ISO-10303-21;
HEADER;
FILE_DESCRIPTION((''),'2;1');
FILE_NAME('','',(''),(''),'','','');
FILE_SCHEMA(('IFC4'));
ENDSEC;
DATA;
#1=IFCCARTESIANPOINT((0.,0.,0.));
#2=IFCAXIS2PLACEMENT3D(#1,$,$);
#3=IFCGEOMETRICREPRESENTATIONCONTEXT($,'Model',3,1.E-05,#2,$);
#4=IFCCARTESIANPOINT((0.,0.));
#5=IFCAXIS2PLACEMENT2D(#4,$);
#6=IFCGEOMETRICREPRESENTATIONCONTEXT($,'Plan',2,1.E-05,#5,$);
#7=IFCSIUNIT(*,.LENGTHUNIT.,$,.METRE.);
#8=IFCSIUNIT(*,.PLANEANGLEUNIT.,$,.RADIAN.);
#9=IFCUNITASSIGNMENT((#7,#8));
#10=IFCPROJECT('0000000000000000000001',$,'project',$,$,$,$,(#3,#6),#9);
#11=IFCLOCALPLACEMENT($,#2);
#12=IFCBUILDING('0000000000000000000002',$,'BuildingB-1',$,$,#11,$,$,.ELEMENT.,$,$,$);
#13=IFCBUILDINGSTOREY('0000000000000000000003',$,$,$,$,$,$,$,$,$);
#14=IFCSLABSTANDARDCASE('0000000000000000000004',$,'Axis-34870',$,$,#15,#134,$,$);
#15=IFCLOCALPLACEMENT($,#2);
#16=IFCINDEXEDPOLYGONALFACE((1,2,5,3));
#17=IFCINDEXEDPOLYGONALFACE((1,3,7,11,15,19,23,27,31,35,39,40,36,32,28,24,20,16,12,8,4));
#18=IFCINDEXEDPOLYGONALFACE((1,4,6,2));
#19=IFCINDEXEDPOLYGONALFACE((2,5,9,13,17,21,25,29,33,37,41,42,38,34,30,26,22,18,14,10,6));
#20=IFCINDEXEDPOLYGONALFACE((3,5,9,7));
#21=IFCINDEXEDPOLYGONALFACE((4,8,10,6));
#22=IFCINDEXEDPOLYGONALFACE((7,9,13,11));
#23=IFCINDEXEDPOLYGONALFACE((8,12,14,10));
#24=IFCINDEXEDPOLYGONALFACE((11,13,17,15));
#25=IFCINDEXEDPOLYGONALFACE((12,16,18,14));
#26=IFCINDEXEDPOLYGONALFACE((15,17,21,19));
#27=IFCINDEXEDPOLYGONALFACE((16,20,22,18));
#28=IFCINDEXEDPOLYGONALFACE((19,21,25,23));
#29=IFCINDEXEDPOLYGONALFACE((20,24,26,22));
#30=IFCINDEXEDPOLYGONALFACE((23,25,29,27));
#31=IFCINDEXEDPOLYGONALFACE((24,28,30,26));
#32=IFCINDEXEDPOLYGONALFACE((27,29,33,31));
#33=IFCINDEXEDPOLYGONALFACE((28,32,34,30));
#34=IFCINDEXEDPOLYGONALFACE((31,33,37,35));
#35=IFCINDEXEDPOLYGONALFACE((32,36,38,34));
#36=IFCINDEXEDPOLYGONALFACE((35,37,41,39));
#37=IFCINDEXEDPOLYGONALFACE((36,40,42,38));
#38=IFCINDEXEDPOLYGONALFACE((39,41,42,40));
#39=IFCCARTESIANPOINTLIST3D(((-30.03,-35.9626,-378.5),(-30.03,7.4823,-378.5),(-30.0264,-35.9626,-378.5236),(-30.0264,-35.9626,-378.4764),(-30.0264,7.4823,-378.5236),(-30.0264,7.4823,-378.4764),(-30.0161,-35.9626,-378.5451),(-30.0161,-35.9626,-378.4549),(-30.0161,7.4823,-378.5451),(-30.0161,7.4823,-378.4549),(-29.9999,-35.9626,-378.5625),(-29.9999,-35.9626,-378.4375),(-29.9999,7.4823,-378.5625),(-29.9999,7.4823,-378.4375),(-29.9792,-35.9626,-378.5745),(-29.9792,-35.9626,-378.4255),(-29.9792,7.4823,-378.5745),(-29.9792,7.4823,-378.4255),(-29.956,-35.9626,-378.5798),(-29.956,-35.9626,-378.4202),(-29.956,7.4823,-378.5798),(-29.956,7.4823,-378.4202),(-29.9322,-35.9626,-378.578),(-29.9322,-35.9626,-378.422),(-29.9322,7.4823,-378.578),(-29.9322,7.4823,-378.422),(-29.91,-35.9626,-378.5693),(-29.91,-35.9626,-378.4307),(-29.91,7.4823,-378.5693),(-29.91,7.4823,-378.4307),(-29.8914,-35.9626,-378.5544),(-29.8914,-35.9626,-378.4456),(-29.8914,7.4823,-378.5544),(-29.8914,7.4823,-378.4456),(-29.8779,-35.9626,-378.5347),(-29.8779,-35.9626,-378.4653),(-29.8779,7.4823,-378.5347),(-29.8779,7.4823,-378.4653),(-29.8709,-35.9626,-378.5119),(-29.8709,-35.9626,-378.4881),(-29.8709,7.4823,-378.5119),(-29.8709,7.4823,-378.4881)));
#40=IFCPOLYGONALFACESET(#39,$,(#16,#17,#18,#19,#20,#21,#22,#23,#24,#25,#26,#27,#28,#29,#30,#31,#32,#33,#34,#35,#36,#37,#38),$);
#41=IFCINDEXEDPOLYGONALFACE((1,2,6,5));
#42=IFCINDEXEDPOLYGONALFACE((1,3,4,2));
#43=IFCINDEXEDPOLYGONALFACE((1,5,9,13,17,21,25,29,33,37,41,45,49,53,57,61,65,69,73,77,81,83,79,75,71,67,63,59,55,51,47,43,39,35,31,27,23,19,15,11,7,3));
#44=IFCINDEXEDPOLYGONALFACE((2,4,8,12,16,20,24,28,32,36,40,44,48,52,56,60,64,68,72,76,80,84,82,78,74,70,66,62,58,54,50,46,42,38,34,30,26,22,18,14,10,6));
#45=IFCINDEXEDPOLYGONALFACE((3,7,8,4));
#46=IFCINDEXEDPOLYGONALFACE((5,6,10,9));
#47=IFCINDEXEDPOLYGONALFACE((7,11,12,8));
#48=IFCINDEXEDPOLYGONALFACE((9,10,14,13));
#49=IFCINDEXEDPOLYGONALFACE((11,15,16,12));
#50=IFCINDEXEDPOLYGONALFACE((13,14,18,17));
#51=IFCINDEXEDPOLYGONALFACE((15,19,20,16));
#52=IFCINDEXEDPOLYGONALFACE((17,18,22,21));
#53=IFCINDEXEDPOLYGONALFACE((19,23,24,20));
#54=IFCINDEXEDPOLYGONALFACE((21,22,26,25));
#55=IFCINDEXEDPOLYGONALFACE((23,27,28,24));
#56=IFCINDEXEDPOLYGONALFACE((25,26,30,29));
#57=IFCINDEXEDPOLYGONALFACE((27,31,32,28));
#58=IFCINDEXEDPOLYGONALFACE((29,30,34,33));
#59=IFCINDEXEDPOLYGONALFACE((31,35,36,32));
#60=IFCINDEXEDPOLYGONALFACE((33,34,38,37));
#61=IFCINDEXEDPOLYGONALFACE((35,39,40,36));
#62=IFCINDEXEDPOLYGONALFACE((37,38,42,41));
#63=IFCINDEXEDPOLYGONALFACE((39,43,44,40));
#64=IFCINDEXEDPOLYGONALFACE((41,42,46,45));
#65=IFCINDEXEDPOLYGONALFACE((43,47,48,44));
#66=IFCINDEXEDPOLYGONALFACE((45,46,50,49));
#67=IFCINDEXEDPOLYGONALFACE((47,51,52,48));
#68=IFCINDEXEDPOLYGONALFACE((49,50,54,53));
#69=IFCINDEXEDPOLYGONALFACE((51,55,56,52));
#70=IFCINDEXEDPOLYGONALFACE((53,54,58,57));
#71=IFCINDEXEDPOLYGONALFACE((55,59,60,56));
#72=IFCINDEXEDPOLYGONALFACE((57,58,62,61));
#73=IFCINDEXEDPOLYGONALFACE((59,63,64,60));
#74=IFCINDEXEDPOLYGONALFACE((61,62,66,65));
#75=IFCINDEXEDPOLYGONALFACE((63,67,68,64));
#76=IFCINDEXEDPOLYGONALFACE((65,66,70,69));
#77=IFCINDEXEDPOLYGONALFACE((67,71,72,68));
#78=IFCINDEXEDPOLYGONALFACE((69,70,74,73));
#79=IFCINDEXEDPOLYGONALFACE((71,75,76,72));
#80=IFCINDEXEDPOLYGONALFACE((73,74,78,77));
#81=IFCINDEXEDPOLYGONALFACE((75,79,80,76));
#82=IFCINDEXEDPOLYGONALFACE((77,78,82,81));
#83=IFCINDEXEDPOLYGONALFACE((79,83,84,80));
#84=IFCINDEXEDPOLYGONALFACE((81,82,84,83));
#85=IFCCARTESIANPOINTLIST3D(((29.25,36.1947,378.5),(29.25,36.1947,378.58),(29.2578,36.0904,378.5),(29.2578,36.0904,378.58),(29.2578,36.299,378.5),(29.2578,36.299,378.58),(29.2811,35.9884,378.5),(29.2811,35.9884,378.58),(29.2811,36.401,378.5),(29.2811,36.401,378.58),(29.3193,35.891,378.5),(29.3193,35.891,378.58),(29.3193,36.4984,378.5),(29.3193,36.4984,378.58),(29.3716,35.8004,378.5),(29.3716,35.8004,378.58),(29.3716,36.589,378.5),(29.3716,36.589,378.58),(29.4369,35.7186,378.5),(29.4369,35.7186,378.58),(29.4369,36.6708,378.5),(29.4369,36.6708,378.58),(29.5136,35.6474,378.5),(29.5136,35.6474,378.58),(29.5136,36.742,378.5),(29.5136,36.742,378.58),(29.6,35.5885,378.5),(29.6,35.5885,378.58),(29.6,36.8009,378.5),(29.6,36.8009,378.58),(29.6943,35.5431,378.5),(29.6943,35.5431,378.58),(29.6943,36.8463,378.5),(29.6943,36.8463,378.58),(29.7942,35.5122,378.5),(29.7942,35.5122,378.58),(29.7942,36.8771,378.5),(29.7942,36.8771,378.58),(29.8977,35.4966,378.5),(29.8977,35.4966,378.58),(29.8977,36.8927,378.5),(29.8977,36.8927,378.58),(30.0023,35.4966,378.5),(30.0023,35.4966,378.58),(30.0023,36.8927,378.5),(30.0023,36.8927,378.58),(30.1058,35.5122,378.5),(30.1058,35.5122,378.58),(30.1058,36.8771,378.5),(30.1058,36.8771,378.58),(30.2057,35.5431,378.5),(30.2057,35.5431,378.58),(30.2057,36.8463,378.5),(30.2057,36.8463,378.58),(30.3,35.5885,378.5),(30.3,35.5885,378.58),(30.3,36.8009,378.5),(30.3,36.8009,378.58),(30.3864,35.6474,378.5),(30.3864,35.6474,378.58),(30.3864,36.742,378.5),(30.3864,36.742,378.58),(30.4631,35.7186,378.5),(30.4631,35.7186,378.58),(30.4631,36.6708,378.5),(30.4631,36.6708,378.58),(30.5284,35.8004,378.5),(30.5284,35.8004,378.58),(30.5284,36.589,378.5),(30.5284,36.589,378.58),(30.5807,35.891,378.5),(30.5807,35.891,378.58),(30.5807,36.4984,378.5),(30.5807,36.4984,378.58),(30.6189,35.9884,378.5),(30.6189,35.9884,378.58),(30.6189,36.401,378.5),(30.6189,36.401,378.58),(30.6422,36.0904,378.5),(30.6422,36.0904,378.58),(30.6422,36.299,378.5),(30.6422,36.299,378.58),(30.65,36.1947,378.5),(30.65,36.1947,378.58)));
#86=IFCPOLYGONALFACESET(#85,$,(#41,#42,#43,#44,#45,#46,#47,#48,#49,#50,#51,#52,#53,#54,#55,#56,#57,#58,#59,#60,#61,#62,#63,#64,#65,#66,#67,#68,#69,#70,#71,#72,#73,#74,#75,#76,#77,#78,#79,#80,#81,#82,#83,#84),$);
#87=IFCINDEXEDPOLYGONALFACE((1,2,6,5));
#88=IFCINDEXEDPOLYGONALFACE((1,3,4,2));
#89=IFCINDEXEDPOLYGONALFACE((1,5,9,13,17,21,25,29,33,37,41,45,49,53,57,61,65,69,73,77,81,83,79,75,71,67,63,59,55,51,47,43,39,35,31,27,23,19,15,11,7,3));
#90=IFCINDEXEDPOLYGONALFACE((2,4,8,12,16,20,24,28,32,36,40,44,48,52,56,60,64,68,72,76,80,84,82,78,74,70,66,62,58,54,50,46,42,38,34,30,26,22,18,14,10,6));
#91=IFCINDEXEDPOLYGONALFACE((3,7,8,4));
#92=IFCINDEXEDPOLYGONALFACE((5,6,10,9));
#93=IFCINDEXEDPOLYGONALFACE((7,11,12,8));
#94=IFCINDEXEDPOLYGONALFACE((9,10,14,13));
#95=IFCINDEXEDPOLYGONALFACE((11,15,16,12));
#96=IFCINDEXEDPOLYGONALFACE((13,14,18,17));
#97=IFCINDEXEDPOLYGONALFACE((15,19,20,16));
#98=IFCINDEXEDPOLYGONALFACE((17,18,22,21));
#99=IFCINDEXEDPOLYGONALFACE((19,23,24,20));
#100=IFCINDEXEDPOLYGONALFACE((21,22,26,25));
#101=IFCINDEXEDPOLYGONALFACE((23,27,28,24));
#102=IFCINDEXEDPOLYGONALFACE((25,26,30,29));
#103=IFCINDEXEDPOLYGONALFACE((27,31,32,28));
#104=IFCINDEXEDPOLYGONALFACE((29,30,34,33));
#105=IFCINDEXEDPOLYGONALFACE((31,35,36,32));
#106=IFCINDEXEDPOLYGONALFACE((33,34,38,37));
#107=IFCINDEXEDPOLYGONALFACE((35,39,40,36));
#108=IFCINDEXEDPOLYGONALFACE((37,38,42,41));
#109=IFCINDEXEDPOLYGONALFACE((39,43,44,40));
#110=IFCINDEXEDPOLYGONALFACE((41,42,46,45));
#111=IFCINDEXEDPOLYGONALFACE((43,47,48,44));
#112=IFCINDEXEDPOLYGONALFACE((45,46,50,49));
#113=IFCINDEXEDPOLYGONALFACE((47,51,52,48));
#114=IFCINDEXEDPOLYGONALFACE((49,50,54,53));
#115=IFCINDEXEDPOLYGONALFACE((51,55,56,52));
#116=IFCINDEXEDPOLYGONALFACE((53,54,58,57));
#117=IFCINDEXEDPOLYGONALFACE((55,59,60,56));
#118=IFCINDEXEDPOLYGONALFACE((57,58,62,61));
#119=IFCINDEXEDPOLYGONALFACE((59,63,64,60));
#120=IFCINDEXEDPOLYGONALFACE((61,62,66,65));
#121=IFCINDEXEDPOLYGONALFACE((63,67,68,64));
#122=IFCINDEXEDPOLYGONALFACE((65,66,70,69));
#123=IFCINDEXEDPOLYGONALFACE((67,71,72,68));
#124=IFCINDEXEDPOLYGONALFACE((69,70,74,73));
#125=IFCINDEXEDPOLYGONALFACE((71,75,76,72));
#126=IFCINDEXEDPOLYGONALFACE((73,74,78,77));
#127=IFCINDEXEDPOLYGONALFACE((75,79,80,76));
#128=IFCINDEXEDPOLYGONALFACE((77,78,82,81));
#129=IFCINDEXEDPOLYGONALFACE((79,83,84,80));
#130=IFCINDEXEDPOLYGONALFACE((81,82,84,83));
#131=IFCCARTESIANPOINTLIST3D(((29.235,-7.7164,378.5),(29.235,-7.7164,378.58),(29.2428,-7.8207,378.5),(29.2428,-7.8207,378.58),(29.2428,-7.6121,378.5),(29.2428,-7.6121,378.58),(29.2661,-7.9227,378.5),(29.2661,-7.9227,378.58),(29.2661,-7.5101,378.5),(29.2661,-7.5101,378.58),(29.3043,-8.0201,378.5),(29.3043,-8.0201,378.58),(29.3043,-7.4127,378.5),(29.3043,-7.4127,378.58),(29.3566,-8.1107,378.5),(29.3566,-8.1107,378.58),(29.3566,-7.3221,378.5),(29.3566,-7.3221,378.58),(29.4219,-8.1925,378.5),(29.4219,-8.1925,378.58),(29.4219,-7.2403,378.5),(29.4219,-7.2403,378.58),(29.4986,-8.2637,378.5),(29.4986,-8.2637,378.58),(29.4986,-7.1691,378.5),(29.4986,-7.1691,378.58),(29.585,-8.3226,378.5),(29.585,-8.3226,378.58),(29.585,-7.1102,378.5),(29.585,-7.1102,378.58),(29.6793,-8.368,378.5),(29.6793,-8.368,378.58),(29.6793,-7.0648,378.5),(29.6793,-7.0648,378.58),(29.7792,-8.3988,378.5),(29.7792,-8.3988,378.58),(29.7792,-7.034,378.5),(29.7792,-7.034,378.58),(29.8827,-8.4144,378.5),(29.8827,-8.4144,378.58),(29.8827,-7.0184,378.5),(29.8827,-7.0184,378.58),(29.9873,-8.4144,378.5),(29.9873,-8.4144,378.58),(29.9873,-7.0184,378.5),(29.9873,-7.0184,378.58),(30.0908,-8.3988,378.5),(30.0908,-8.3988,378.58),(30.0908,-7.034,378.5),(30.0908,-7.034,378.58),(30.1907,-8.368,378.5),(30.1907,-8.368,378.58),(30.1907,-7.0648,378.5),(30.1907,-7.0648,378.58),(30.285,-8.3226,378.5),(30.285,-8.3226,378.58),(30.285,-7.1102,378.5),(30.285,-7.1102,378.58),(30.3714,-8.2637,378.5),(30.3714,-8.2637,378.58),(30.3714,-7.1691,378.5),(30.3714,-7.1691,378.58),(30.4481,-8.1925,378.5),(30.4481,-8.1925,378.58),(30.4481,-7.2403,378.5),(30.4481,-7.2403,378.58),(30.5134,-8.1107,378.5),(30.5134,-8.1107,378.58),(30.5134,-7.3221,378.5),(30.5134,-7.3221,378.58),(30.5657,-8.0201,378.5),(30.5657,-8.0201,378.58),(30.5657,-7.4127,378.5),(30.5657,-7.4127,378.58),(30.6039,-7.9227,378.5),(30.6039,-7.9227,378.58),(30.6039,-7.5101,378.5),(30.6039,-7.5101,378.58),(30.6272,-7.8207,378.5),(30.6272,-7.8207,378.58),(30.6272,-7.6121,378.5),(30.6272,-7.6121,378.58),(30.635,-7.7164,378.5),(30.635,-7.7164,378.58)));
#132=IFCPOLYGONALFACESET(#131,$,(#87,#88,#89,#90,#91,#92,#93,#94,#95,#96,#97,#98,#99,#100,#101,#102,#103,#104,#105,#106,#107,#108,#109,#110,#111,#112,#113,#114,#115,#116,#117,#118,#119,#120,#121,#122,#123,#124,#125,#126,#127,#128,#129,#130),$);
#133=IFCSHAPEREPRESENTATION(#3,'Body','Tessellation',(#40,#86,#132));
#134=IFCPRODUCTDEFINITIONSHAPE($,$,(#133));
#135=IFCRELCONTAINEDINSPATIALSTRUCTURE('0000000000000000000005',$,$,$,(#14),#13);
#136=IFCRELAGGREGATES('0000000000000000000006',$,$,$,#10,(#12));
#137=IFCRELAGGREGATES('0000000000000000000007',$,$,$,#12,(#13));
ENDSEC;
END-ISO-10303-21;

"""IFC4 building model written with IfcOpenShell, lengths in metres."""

from ifc_helpers import new_model, entity, si_unit, frame, origin, origin_2d, place, context, project, spatial, circle, extrude, element, save


model = new_model("IFC4")

# Units and contexts
model_context = context("Model", 3, precision=1e-05, world=origin())
plan_context = context("Plan", 2, precision=1e-05, world=origin_2d())
ifc_project = project(units=[si_unit("LENGTHUNIT", "METRE"), si_unit("PLANEANGLEUNIT", "RADIAN")], contexts=[model_context, plan_context])

# Building, storey
building_placement = place(None, origin())
building = spatial("IfcBuilding", under=ifc_project, at=building_placement, Name="BuildingB-1", CompositionType="ELEMENT")
storey = spatial("IfcBuildingStorey", under=building)

# Slab
element("IfcSlabStandardCase", 1, inside=storey, Name="Axis-34870", context=model_context, shape_type="AdvancedSweptSolid", body=[
    entity("IfcSurfaceCurveSweptAreaSolid", entity("IfcCircleProfileDef", "AREA", None, None, 0.08), None, entity("IfcPolyline", [entity("IfcCartesianPoint", [29.95, 35.9626, 378.5]), entity("IfcCartesianPoint", [29.95, -7.4823, 378.5])]), None, None, entity("IfcPlane", entity("IfcAxis2Placement3D", entity("IfcCartesianPoint", [29.95, 35.9626, 378.5]), entity("IfcDirection", [0.0, 0.0, 1.0]), entity("IfcDirection", [1.0, 0.0, 0.0])))),
    extrude(circle(Radius=0.7), frame((29.95, 36.1947, 378.5)), (0.0, 0.0, 1.0), 0.08),
    extrude(circle(Radius=0.7), frame((29.935, -7.7164, 378.5)), (0.0, 0.0, 1.0), 0.08),
])

save(model, "model.ifc")
